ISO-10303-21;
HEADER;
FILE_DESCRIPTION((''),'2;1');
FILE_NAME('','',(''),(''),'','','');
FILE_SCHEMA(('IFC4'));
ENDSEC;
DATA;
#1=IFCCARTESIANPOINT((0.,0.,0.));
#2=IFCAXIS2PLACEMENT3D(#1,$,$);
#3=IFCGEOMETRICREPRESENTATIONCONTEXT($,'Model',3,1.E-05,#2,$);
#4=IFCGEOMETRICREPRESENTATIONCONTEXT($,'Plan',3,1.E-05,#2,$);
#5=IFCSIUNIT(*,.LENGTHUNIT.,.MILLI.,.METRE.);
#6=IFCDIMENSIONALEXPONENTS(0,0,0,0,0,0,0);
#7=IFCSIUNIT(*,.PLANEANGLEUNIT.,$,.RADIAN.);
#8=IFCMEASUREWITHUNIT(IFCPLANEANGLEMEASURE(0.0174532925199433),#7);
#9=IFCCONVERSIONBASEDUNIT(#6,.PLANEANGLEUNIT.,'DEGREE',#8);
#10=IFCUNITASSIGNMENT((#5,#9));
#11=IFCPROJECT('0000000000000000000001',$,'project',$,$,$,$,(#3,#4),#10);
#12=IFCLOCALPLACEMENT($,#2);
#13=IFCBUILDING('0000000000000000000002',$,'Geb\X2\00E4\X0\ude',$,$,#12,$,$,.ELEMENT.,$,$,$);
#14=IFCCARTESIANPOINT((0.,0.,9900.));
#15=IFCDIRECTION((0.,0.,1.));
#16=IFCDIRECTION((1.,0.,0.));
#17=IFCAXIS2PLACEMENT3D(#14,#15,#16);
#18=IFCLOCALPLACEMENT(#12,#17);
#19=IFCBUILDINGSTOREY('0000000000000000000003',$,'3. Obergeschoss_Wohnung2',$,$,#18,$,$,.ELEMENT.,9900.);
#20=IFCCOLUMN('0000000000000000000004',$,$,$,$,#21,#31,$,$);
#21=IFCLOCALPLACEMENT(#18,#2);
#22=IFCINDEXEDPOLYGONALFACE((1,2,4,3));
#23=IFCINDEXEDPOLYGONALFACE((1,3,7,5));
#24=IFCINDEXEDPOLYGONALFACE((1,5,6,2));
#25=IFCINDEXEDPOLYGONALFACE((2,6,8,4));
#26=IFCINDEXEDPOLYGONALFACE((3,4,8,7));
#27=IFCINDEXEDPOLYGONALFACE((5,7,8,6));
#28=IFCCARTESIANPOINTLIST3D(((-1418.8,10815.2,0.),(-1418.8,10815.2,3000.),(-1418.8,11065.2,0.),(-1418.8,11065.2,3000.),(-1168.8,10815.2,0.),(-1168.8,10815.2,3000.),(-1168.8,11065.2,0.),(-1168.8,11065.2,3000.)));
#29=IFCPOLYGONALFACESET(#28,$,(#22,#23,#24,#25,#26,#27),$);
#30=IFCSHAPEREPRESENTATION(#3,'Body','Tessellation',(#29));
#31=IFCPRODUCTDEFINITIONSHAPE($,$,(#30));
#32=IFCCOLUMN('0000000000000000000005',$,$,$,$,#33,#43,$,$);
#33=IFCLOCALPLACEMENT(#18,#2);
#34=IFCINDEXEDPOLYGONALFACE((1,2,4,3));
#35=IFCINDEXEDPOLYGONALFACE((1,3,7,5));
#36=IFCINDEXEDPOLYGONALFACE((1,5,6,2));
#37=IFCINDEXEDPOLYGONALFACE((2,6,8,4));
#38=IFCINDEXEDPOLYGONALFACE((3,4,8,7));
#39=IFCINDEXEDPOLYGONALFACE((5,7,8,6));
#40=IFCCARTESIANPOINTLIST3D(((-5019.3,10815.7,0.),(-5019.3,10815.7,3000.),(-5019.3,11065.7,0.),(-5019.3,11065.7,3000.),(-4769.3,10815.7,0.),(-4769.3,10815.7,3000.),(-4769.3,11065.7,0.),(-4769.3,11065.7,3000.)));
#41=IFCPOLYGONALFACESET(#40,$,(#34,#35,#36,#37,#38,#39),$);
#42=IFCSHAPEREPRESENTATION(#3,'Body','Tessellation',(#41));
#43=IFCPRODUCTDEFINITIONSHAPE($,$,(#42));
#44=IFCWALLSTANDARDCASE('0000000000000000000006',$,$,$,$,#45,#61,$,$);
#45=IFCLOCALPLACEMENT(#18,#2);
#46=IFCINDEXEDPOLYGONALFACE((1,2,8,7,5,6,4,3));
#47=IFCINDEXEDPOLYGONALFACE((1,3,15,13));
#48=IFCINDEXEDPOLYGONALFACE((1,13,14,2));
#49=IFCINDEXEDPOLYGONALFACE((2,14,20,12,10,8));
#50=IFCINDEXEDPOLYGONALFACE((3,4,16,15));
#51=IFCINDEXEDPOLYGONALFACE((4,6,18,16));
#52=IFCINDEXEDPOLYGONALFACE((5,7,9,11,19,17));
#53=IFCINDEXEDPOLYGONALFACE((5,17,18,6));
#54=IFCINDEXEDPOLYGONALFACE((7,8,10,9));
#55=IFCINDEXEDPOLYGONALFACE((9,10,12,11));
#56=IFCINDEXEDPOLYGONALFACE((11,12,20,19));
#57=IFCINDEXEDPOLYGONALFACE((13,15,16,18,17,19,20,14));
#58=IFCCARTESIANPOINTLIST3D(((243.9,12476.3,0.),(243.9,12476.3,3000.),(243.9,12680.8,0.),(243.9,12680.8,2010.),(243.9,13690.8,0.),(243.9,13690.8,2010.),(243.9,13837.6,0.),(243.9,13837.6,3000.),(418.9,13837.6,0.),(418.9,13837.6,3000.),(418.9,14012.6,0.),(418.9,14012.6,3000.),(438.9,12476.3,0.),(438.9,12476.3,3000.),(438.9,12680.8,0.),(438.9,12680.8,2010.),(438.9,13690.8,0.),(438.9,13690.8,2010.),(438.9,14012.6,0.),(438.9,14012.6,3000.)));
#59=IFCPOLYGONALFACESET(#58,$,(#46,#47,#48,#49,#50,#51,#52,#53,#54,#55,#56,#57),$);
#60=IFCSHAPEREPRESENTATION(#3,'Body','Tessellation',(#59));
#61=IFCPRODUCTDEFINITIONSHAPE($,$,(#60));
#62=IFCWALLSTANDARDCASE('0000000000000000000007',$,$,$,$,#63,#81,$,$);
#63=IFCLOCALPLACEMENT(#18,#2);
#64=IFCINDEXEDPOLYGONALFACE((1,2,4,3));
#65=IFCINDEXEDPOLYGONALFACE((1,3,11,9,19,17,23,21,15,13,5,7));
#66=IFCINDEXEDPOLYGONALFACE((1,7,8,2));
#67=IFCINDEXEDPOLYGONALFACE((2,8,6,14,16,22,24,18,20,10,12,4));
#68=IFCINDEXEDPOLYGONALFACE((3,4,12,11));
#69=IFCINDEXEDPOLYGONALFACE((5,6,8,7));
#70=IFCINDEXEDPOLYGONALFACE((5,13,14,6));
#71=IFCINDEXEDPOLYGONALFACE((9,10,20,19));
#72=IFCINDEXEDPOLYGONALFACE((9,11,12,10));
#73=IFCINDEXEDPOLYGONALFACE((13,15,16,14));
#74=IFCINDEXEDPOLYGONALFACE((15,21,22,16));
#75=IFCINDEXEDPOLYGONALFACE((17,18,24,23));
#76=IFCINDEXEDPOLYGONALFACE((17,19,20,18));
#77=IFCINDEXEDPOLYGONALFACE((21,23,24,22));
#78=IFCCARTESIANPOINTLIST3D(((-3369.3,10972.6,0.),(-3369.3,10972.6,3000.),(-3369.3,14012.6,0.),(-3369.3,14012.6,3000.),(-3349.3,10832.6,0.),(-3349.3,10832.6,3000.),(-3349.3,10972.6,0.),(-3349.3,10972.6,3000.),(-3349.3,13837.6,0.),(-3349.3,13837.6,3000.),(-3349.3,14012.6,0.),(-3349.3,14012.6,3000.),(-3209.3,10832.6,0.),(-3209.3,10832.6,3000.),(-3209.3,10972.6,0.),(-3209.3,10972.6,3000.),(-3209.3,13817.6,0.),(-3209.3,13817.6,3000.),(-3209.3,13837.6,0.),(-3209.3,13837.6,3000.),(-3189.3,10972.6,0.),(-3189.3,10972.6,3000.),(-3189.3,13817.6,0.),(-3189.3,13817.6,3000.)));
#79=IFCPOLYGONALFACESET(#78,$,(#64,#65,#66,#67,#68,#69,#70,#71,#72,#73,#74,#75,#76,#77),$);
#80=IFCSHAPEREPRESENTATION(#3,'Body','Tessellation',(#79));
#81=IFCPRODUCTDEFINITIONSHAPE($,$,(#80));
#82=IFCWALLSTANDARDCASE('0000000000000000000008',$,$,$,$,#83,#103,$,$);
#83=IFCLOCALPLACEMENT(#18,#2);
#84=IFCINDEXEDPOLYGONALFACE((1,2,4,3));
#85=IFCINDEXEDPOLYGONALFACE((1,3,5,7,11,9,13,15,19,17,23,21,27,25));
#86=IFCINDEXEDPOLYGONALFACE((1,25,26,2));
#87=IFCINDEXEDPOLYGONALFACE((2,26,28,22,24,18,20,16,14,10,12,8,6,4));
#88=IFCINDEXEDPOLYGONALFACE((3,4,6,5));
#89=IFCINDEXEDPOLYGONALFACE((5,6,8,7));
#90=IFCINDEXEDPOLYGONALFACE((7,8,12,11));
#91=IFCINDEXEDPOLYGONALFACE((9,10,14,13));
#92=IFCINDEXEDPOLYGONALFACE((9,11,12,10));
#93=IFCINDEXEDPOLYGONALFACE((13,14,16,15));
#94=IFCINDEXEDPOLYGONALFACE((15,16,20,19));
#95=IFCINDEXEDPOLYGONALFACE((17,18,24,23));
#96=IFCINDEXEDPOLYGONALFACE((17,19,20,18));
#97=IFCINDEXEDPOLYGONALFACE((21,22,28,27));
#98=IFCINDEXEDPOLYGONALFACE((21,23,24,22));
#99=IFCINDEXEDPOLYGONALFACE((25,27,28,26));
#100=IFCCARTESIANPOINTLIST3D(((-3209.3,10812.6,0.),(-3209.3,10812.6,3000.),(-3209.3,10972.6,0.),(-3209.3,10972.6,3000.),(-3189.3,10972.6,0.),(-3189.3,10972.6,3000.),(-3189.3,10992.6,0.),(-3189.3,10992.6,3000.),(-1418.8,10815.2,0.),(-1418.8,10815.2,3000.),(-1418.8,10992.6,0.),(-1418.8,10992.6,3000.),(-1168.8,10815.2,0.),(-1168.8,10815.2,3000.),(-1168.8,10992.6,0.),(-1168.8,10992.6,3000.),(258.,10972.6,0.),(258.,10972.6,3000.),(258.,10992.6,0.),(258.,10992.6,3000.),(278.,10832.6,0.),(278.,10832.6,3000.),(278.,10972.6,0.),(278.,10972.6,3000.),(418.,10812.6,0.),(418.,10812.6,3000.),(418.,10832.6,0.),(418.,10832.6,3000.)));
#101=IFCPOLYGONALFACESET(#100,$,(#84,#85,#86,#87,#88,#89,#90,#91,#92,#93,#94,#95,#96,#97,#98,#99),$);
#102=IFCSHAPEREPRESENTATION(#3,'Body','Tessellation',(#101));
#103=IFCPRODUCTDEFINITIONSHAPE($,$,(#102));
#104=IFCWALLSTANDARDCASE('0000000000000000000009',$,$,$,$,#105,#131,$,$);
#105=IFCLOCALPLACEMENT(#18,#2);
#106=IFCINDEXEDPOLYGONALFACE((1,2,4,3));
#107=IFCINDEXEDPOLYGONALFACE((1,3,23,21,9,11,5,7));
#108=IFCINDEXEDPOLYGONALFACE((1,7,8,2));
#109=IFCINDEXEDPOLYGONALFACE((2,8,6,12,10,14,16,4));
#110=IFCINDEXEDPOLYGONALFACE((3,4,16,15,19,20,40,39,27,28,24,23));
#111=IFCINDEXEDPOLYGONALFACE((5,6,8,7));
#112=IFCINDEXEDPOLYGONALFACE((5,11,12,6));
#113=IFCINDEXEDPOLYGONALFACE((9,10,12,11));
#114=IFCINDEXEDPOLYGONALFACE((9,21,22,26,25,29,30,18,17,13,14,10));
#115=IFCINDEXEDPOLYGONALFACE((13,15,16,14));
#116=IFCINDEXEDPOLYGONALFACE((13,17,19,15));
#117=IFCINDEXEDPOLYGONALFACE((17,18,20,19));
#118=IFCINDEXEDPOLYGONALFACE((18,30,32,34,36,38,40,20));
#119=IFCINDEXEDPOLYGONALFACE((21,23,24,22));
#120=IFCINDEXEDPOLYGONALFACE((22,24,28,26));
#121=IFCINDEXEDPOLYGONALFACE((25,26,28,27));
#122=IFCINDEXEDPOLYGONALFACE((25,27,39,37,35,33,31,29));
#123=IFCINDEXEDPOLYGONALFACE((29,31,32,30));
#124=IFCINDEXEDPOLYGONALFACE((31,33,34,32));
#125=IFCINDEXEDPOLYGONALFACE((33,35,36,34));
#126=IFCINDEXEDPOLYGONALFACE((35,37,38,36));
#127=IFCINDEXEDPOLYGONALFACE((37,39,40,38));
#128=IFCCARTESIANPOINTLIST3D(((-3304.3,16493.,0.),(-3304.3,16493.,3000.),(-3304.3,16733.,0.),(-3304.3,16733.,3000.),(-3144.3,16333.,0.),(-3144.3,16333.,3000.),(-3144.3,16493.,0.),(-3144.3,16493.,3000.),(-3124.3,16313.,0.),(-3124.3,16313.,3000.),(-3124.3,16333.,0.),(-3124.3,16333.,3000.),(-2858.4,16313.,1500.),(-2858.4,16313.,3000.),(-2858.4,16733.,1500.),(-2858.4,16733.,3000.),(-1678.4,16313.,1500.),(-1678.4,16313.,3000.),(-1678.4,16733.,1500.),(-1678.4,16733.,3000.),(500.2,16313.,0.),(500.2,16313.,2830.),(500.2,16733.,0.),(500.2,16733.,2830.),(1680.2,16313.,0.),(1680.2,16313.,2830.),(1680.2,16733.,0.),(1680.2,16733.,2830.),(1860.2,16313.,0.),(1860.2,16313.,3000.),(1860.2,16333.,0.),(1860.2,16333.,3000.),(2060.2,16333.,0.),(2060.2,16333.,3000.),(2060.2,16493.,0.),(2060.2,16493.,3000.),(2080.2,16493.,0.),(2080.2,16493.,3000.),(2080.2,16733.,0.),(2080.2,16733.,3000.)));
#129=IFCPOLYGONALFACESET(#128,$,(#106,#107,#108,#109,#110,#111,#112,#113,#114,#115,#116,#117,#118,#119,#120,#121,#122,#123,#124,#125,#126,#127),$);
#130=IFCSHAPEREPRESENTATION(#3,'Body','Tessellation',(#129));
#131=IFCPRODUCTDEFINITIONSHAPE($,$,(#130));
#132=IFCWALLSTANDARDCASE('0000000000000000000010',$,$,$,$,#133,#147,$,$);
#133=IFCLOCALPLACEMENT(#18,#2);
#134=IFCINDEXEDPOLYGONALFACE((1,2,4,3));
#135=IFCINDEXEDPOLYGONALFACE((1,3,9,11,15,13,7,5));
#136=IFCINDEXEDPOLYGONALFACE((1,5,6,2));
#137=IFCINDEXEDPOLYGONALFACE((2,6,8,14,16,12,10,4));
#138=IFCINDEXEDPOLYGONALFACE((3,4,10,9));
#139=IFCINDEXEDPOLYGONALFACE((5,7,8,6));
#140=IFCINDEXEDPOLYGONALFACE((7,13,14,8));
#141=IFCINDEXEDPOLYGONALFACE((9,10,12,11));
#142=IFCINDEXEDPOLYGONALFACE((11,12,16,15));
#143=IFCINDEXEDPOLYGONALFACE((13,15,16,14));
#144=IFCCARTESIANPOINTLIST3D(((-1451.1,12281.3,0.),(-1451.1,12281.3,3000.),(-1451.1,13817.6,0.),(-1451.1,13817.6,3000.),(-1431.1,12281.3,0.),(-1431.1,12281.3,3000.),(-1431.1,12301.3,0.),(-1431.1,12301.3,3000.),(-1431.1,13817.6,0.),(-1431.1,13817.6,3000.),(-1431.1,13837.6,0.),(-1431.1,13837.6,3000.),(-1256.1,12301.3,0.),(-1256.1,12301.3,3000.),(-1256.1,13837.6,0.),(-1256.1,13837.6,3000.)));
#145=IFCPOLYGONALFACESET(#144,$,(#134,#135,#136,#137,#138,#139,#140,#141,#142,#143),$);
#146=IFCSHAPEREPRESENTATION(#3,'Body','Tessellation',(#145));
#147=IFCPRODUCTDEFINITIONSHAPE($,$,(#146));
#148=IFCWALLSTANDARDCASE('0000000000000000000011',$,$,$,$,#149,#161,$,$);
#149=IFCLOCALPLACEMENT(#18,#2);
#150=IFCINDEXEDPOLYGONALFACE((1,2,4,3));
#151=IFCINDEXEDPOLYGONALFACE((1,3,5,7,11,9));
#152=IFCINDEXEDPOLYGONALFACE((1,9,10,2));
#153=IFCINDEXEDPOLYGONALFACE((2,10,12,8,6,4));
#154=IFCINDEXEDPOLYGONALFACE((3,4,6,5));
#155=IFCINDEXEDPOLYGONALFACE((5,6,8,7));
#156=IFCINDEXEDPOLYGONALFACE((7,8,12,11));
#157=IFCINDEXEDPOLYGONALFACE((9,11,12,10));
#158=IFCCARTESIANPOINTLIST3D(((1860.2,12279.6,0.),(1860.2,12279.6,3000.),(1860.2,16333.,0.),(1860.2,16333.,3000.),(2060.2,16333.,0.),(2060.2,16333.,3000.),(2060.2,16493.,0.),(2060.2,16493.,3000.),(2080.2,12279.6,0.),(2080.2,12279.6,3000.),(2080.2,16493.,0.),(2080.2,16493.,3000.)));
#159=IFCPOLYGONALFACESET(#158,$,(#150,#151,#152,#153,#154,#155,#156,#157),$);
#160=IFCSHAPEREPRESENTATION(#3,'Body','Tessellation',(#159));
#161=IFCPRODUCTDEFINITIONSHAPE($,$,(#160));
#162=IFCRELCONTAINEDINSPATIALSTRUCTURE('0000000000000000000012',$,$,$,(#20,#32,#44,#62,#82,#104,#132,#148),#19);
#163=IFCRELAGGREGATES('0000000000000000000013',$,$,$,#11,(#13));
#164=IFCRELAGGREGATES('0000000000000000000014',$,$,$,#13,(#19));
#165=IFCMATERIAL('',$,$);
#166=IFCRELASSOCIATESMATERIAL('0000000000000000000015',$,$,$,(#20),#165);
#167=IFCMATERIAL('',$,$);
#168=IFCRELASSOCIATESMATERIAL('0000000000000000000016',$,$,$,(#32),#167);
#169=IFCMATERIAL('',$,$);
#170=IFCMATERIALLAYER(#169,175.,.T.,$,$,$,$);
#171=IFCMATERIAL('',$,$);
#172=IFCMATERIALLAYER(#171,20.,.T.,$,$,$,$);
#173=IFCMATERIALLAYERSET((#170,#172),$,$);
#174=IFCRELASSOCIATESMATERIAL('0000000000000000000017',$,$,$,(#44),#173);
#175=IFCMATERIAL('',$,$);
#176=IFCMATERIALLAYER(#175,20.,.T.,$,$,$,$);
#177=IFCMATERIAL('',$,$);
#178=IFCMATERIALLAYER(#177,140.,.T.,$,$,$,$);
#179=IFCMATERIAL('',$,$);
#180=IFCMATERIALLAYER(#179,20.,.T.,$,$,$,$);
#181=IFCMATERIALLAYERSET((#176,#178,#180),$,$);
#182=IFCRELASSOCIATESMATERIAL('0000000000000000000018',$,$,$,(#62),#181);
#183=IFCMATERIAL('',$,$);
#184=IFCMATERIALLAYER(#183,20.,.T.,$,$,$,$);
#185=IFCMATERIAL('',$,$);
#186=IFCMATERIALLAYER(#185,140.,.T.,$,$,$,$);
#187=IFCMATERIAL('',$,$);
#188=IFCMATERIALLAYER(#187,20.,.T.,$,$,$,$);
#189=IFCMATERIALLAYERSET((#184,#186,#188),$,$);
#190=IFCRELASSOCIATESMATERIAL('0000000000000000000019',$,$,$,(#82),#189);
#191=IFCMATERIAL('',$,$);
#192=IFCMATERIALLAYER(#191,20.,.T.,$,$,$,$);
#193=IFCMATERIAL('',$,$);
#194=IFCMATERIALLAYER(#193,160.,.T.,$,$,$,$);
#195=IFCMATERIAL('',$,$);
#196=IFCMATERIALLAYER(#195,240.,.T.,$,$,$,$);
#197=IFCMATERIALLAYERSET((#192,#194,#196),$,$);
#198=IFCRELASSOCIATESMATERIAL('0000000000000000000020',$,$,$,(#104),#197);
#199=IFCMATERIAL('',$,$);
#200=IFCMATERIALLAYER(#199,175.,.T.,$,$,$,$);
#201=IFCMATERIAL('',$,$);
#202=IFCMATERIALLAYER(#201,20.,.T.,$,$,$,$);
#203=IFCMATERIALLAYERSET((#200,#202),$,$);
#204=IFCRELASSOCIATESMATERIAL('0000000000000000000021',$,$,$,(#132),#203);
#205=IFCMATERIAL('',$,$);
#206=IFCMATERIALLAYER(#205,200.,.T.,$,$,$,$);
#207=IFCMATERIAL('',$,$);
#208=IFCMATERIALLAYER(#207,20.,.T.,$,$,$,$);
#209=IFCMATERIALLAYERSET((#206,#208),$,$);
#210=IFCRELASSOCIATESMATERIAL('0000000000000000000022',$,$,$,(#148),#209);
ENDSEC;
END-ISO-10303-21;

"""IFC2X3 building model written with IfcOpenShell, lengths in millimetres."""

from ifc_helpers import new_model, entity, si_unit, converted_unit, frame, frame_2d, origin, origin_with_axes, place, context, project, spatial, polyline, rectangle, outline, extrude, material, layer, layer_set, layer_usage, element, save


model = new_model("IFC2X3")

# Units and contexts
model_context = context("Model", 3, precision=1e-05, world=origin())
plan_context = context("Plan", 3, precision=1e-05, world=origin())
ifc_project = project(units=[si_unit("LENGTHUNIT", "METRE", prefix="MILLI"), converted_unit("PLANEANGLEUNIT", "DEGREE", entity("IfcPlaneAngleMeasure", 0.0174532925199433), si_unit("PLANEANGLEUNIT", "RADIAN"), dimensions=[0, 0, 0, 0, 0, 0, 0])], contexts=[model_context, plan_context])

# Building, storey
building_placement = place(None, origin())
building = spatial("IfcBuilding", under=ifc_project, at=building_placement, Name="Gebäude", CompositionType="ELEMENT")
storey_placement = place(building_placement, frame((0.0, 0.0, 9900.0), z_axis=(0.0, 0.0, 1.0), x_axis=(1.0, 0.0, 0.0)))
storey = spatial("IfcBuildingStorey", under=building, at=storey_placement, Name="3. Obergeschoss_Wohnung2", CompositionType="ELEMENT", Elevation=9900.0)

# Columns
ifc_material_1 = material(Name="")
column_1_placement = place(storey_placement, frame((-1418.8, 10815.2, 0.0), z_axis=(0.0, 0.0, 1.0), x_axis=(1.0, 0.0, 0.0)))
element("IfcColumn", 1, at=column_1_placement, inside=storey, material=ifc_material_1, context=model_context, shape_type="SweptSolid", body=[
    extrude(rectangle(XDim=250.0, YDim=250.0, at=frame_2d((125.0, 125.0), x_axis=(1.0, 0.0))), origin_with_axes(), (0.0, 0.0, 1.0), 3000.0),
])
ifc_material_2 = material(Name="")
column_2_placement = place(storey_placement, frame((-5019.3, 10815.7, 0.0), z_axis=(0.0, 0.0, 1.0), x_axis=(1.0, 0.0, 0.0)))
element("IfcColumn", 2, at=column_2_placement, inside=storey, material=ifc_material_2, context=model_context, shape_type="SweptSolid", body=[
    extrude(rectangle(XDim=250.0, YDim=250.0, at=frame_2d((125.0, 125.0), x_axis=(1.0, 0.0))), origin_with_axes(), (0.0, 0.0, 1.0), 3000.0),
])

# Wall, opening
ifc_material_3 = material(Name="")
ifc_layer_1 = layer(ifc_material_3, 175.0, ventilated=True)
ifc_material_4 = material(Name="")
ifc_layer_2 = layer(ifc_material_4, 20.0, ventilated=True)
ifc_layer_set_1 = layer_set([ifc_layer_1, ifc_layer_2])
ifc_layer_usage_1 = layer_usage(ifc_layer_set_1, "AXIS2", "POSITIVE", -195.0)
wall_1_placement = place(storey_placement, frame((438.9, 12476.3, 0.0), z_axis=(0.0, 0.0, 1.0), x_axis=(0.0, 1.0, 0.0)))
wall_1 = element("IfcWallStandardCase", 3, at=wall_1_placement, inside=storey, material=ifc_layer_usage_1, context=model_context, shape_type="SweptSolid", body=[
    extrude(outline(polyline([(0.0, 0.0), (1536.4, 0.0), (1536.4, 20.0), (1361.4, 20.0), (1361.4, 195.0), (0.0, 195.0), (0.0, 0.0)])), origin_with_axes(), (0.0, 0.0, 1.0), 3000.0),
])
opening_1_placement = place(wall_1_placement, frame((204.6, 0.0, 0.0), z_axis=(0.0, 1.0, 0.0), x_axis=(0.0, 0.0, 1.0)))
element("IfcOpeningElement", 4, at=opening_1_placement, cuts=wall_1, ObjectType="Opening", context=model_context, shape_type="SweptSolid", body=[
    extrude(rectangle(XDim=2010.0, YDim=1010.0, at=frame_2d((1005.0, 505.0), x_axis=(1.0, 0.0))), origin_with_axes(), (0.0, 0.0, 1.0), 195.0),
])

# Walls
ifc_material_5 = material(Name="")
ifc_layer_3 = layer(ifc_material_5, 20.0, ventilated=True)
ifc_material_6 = material(Name="")
ifc_layer_4 = layer(ifc_material_6, 140.0, ventilated=True)
ifc_material_7 = material(Name="")
ifc_layer_5 = layer(ifc_material_7, 20.0, ventilated=True)
ifc_layer_set_2 = layer_set([ifc_layer_3, ifc_layer_4, ifc_layer_5])
ifc_layer_usage_2 = layer_usage(ifc_layer_set_2, "AXIS2", "POSITIVE", 0.0)
wall_2_placement = place(storey_placement, frame((-3369.3, 14012.6, 0.0), z_axis=(0.0, 0.0, 1.0), x_axis=(0.0, -1.0, 0.0)))
element("IfcWallStandardCase", 5, at=wall_2_placement, inside=storey, material=ifc_layer_usage_2, context=model_context, shape_type="SweptSolid", body=[
    extrude(outline(polyline([(0.0, 0.0), (3040.0, 0.0), (3040.0, 20.0), (3180.0, 20.0), (3180.0, 160.0), (3040.0, 160.0), (3040.0, 180.0), (195.0, 180.0), (195.0, 160.0), (175.0, 160.0), (175.0, 20.0), (0.0, 20.0), (0.0, 0.0)])), origin_with_axes(), (0.0, 0.0, 1.0), 3000.0),
])
ifc_material_8 = material(Name="")
ifc_layer_6 = layer(ifc_material_8, 20.0, ventilated=True)
ifc_material_9 = material(Name="")
ifc_layer_7 = layer(ifc_material_9, 140.0, ventilated=True)
ifc_material_10 = material(Name="")
ifc_layer_8 = layer(ifc_material_10, 20.0, ventilated=True)
ifc_layer_set_3 = layer_set([ifc_layer_6, ifc_layer_7, ifc_layer_8])
ifc_layer_usage_3 = layer_usage(ifc_layer_set_3, "AXIS2", "POSITIVE", 0.0)
wall_3_placement = place(storey_placement, frame((-3209.3, 10812.6, 0.0), z_axis=(0.0, 0.0, 1.0), x_axis=(1.0, 0.0, 0.0)))
element("IfcWallStandardCase", 6, at=wall_3_placement, inside=storey, material=ifc_layer_usage_3, context=model_context, shape_type="SweptSolid", body=[
    extrude(outline(polyline([(20.0, 180.0), (20.0, 160.0), (0.0, 160.0), (0.0, 0.0), (3627.2, 0.0), (3627.2, 20.0), (3487.2, 20.0), (3487.2, 160.0), (3467.2, 160.0), (3467.2, 180.0), (2040.5, 180.0), (2040.5, 2.6), (1790.5, 2.6), (1790.5, 180.0), (20.0, 180.0)])), origin_with_axes(), (0.0, 0.0, 1.0), 3000.0),
])

# Wall, openings
ifc_material_11 = material(Name="")
ifc_layer_9 = layer(ifc_material_11, 20.0, ventilated=True)
ifc_material_12 = material(Name="")
ifc_layer_10 = layer(ifc_material_12, 160.0, ventilated=True)
ifc_material_13 = material(Name="")
ifc_layer_11 = layer(ifc_material_13, 240.0, ventilated=True)
ifc_layer_set_4 = layer_set([ifc_layer_9, ifc_layer_10, ifc_layer_11])
ifc_layer_usage_4 = layer_usage(ifc_layer_set_4, "AXIS2", "POSITIVE", -420.0)
wall_4_placement = place(storey_placement, frame((-3124.3, 16313.0, 0.0), z_axis=(0.0, 0.0, 1.0), x_axis=(1.0, 0.0, 0.0)))
wall_4 = element("IfcWallStandardCase", 7, at=wall_4_placement, inside=storey, material=ifc_layer_usage_4, context=model_context, shape_type="SweptSolid", body=[
    extrude(outline(polyline([(0.0, 0.0), (4984.5, 0.0), (4984.5, 20.0), (5184.5, 20.0), (5184.5, 180.0), (5204.5, 180.0), (5204.5, 420.0), (-180.0, 420.0), (-180.0, 180.0), (-20.0, 180.0), (-20.0, 20.0), (0.0, 20.0), (0.0, 0.0)])), origin_with_axes(), (0.0, 0.0, 1.0), 3000.0),
])
opening_2_placement = place(wall_4_placement, frame((3624.5, 0.0, 0.0), z_axis=(0.0, 1.0, 0.0), x_axis=(0.0, 0.0, 1.0)))
element("IfcOpeningElement", 8, at=opening_2_placement, cuts=wall_4, ObjectType="Opening", context=model_context, shape_type="SweptSolid", body=[
    extrude(rectangle(XDim=2830.0, YDim=1180.0, at=frame_2d((1415.0, 590.0), x_axis=(1.0, 0.0))), origin_with_axes(), (0.0, 0.0, 1.0), 420.0),
])
opening_3_placement = place(wall_4_placement, frame((265.9, 0.0, 1500.0), z_axis=(0.0, 1.0, 0.0), x_axis=(0.0, 0.0, 1.0)))
element("IfcOpeningElement", 9, at=opening_3_placement, cuts=wall_4, ObjectType="Opening", context=model_context, shape_type="SweptSolid", body=[
    extrude(rectangle(XDim=2830.0, YDim=1180.0, at=frame_2d((1415.0, 590.0), x_axis=(1.0, 0.0))), origin_with_axes(), (0.0, 0.0, 1.0), 420.0),
])

# Walls
ifc_material_14 = material(Name="")
ifc_layer_12 = layer(ifc_material_14, 175.0, ventilated=True)
ifc_material_15 = material(Name="")
ifc_layer_13 = layer(ifc_material_15, 20.0, ventilated=True)
ifc_layer_set_5 = layer_set([ifc_layer_12, ifc_layer_13])
ifc_layer_usage_5 = layer_usage(ifc_layer_set_5, "AXIS2", "POSITIVE", -195.0)
wall_5_placement = place(storey_placement, frame((-1451.1, 13817.6, 0.0), z_axis=(0.0, 0.0, 1.0), x_axis=(0.0, -1.0, 0.0)))
element("IfcWallStandardCase", 10, at=wall_5_placement, inside=storey, material=ifc_layer_usage_5, context=model_context, shape_type="SweptSolid", body=[
    extrude(outline(polyline([(0.0, 0.0), (1536.4, 0.0), (1536.4, 20.0), (1516.4, 20.0), (1516.4, 195.0), (-20.0, 195.0), (-20.0, 20.0), (0.0, 20.0), (0.0, 0.0)])), origin_with_axes(), (0.0, 0.0, 1.0), 3000.0),
])
ifc_material_16 = material(Name="")
ifc_layer_14 = layer(ifc_material_16, 200.0, ventilated=True)
ifc_material_17 = material(Name="")
ifc_layer_15 = layer(ifc_material_17, 20.0, ventilated=True)
ifc_layer_set_6 = layer_set([ifc_layer_14, ifc_layer_15])
ifc_layer_usage_6 = layer_usage(ifc_layer_set_6, "AXIS2", "POSITIVE", 0.0)
wall_6_placement = place(storey_placement, frame((2080.2, 12279.6, 0.0), z_axis=(0.0, 0.0, 1.0), x_axis=(0.0, 1.0, 0.0)))
element("IfcWallStandardCase", 11, at=wall_6_placement, inside=storey, material=ifc_layer_usage_6, context=model_context, shape_type="SweptSolid", body=[
    extrude(outline(polyline([(0.0, 0.0), (4213.4, 0.0), (4213.4, 20.0), (4053.4, 20.0), (4053.4, 220.0), (0.0, 220.0), (0.0, 0.0)])), origin_with_axes(), (0.0, 0.0, 1.0), 3000.0),
])

save(model, "model.ifc")
